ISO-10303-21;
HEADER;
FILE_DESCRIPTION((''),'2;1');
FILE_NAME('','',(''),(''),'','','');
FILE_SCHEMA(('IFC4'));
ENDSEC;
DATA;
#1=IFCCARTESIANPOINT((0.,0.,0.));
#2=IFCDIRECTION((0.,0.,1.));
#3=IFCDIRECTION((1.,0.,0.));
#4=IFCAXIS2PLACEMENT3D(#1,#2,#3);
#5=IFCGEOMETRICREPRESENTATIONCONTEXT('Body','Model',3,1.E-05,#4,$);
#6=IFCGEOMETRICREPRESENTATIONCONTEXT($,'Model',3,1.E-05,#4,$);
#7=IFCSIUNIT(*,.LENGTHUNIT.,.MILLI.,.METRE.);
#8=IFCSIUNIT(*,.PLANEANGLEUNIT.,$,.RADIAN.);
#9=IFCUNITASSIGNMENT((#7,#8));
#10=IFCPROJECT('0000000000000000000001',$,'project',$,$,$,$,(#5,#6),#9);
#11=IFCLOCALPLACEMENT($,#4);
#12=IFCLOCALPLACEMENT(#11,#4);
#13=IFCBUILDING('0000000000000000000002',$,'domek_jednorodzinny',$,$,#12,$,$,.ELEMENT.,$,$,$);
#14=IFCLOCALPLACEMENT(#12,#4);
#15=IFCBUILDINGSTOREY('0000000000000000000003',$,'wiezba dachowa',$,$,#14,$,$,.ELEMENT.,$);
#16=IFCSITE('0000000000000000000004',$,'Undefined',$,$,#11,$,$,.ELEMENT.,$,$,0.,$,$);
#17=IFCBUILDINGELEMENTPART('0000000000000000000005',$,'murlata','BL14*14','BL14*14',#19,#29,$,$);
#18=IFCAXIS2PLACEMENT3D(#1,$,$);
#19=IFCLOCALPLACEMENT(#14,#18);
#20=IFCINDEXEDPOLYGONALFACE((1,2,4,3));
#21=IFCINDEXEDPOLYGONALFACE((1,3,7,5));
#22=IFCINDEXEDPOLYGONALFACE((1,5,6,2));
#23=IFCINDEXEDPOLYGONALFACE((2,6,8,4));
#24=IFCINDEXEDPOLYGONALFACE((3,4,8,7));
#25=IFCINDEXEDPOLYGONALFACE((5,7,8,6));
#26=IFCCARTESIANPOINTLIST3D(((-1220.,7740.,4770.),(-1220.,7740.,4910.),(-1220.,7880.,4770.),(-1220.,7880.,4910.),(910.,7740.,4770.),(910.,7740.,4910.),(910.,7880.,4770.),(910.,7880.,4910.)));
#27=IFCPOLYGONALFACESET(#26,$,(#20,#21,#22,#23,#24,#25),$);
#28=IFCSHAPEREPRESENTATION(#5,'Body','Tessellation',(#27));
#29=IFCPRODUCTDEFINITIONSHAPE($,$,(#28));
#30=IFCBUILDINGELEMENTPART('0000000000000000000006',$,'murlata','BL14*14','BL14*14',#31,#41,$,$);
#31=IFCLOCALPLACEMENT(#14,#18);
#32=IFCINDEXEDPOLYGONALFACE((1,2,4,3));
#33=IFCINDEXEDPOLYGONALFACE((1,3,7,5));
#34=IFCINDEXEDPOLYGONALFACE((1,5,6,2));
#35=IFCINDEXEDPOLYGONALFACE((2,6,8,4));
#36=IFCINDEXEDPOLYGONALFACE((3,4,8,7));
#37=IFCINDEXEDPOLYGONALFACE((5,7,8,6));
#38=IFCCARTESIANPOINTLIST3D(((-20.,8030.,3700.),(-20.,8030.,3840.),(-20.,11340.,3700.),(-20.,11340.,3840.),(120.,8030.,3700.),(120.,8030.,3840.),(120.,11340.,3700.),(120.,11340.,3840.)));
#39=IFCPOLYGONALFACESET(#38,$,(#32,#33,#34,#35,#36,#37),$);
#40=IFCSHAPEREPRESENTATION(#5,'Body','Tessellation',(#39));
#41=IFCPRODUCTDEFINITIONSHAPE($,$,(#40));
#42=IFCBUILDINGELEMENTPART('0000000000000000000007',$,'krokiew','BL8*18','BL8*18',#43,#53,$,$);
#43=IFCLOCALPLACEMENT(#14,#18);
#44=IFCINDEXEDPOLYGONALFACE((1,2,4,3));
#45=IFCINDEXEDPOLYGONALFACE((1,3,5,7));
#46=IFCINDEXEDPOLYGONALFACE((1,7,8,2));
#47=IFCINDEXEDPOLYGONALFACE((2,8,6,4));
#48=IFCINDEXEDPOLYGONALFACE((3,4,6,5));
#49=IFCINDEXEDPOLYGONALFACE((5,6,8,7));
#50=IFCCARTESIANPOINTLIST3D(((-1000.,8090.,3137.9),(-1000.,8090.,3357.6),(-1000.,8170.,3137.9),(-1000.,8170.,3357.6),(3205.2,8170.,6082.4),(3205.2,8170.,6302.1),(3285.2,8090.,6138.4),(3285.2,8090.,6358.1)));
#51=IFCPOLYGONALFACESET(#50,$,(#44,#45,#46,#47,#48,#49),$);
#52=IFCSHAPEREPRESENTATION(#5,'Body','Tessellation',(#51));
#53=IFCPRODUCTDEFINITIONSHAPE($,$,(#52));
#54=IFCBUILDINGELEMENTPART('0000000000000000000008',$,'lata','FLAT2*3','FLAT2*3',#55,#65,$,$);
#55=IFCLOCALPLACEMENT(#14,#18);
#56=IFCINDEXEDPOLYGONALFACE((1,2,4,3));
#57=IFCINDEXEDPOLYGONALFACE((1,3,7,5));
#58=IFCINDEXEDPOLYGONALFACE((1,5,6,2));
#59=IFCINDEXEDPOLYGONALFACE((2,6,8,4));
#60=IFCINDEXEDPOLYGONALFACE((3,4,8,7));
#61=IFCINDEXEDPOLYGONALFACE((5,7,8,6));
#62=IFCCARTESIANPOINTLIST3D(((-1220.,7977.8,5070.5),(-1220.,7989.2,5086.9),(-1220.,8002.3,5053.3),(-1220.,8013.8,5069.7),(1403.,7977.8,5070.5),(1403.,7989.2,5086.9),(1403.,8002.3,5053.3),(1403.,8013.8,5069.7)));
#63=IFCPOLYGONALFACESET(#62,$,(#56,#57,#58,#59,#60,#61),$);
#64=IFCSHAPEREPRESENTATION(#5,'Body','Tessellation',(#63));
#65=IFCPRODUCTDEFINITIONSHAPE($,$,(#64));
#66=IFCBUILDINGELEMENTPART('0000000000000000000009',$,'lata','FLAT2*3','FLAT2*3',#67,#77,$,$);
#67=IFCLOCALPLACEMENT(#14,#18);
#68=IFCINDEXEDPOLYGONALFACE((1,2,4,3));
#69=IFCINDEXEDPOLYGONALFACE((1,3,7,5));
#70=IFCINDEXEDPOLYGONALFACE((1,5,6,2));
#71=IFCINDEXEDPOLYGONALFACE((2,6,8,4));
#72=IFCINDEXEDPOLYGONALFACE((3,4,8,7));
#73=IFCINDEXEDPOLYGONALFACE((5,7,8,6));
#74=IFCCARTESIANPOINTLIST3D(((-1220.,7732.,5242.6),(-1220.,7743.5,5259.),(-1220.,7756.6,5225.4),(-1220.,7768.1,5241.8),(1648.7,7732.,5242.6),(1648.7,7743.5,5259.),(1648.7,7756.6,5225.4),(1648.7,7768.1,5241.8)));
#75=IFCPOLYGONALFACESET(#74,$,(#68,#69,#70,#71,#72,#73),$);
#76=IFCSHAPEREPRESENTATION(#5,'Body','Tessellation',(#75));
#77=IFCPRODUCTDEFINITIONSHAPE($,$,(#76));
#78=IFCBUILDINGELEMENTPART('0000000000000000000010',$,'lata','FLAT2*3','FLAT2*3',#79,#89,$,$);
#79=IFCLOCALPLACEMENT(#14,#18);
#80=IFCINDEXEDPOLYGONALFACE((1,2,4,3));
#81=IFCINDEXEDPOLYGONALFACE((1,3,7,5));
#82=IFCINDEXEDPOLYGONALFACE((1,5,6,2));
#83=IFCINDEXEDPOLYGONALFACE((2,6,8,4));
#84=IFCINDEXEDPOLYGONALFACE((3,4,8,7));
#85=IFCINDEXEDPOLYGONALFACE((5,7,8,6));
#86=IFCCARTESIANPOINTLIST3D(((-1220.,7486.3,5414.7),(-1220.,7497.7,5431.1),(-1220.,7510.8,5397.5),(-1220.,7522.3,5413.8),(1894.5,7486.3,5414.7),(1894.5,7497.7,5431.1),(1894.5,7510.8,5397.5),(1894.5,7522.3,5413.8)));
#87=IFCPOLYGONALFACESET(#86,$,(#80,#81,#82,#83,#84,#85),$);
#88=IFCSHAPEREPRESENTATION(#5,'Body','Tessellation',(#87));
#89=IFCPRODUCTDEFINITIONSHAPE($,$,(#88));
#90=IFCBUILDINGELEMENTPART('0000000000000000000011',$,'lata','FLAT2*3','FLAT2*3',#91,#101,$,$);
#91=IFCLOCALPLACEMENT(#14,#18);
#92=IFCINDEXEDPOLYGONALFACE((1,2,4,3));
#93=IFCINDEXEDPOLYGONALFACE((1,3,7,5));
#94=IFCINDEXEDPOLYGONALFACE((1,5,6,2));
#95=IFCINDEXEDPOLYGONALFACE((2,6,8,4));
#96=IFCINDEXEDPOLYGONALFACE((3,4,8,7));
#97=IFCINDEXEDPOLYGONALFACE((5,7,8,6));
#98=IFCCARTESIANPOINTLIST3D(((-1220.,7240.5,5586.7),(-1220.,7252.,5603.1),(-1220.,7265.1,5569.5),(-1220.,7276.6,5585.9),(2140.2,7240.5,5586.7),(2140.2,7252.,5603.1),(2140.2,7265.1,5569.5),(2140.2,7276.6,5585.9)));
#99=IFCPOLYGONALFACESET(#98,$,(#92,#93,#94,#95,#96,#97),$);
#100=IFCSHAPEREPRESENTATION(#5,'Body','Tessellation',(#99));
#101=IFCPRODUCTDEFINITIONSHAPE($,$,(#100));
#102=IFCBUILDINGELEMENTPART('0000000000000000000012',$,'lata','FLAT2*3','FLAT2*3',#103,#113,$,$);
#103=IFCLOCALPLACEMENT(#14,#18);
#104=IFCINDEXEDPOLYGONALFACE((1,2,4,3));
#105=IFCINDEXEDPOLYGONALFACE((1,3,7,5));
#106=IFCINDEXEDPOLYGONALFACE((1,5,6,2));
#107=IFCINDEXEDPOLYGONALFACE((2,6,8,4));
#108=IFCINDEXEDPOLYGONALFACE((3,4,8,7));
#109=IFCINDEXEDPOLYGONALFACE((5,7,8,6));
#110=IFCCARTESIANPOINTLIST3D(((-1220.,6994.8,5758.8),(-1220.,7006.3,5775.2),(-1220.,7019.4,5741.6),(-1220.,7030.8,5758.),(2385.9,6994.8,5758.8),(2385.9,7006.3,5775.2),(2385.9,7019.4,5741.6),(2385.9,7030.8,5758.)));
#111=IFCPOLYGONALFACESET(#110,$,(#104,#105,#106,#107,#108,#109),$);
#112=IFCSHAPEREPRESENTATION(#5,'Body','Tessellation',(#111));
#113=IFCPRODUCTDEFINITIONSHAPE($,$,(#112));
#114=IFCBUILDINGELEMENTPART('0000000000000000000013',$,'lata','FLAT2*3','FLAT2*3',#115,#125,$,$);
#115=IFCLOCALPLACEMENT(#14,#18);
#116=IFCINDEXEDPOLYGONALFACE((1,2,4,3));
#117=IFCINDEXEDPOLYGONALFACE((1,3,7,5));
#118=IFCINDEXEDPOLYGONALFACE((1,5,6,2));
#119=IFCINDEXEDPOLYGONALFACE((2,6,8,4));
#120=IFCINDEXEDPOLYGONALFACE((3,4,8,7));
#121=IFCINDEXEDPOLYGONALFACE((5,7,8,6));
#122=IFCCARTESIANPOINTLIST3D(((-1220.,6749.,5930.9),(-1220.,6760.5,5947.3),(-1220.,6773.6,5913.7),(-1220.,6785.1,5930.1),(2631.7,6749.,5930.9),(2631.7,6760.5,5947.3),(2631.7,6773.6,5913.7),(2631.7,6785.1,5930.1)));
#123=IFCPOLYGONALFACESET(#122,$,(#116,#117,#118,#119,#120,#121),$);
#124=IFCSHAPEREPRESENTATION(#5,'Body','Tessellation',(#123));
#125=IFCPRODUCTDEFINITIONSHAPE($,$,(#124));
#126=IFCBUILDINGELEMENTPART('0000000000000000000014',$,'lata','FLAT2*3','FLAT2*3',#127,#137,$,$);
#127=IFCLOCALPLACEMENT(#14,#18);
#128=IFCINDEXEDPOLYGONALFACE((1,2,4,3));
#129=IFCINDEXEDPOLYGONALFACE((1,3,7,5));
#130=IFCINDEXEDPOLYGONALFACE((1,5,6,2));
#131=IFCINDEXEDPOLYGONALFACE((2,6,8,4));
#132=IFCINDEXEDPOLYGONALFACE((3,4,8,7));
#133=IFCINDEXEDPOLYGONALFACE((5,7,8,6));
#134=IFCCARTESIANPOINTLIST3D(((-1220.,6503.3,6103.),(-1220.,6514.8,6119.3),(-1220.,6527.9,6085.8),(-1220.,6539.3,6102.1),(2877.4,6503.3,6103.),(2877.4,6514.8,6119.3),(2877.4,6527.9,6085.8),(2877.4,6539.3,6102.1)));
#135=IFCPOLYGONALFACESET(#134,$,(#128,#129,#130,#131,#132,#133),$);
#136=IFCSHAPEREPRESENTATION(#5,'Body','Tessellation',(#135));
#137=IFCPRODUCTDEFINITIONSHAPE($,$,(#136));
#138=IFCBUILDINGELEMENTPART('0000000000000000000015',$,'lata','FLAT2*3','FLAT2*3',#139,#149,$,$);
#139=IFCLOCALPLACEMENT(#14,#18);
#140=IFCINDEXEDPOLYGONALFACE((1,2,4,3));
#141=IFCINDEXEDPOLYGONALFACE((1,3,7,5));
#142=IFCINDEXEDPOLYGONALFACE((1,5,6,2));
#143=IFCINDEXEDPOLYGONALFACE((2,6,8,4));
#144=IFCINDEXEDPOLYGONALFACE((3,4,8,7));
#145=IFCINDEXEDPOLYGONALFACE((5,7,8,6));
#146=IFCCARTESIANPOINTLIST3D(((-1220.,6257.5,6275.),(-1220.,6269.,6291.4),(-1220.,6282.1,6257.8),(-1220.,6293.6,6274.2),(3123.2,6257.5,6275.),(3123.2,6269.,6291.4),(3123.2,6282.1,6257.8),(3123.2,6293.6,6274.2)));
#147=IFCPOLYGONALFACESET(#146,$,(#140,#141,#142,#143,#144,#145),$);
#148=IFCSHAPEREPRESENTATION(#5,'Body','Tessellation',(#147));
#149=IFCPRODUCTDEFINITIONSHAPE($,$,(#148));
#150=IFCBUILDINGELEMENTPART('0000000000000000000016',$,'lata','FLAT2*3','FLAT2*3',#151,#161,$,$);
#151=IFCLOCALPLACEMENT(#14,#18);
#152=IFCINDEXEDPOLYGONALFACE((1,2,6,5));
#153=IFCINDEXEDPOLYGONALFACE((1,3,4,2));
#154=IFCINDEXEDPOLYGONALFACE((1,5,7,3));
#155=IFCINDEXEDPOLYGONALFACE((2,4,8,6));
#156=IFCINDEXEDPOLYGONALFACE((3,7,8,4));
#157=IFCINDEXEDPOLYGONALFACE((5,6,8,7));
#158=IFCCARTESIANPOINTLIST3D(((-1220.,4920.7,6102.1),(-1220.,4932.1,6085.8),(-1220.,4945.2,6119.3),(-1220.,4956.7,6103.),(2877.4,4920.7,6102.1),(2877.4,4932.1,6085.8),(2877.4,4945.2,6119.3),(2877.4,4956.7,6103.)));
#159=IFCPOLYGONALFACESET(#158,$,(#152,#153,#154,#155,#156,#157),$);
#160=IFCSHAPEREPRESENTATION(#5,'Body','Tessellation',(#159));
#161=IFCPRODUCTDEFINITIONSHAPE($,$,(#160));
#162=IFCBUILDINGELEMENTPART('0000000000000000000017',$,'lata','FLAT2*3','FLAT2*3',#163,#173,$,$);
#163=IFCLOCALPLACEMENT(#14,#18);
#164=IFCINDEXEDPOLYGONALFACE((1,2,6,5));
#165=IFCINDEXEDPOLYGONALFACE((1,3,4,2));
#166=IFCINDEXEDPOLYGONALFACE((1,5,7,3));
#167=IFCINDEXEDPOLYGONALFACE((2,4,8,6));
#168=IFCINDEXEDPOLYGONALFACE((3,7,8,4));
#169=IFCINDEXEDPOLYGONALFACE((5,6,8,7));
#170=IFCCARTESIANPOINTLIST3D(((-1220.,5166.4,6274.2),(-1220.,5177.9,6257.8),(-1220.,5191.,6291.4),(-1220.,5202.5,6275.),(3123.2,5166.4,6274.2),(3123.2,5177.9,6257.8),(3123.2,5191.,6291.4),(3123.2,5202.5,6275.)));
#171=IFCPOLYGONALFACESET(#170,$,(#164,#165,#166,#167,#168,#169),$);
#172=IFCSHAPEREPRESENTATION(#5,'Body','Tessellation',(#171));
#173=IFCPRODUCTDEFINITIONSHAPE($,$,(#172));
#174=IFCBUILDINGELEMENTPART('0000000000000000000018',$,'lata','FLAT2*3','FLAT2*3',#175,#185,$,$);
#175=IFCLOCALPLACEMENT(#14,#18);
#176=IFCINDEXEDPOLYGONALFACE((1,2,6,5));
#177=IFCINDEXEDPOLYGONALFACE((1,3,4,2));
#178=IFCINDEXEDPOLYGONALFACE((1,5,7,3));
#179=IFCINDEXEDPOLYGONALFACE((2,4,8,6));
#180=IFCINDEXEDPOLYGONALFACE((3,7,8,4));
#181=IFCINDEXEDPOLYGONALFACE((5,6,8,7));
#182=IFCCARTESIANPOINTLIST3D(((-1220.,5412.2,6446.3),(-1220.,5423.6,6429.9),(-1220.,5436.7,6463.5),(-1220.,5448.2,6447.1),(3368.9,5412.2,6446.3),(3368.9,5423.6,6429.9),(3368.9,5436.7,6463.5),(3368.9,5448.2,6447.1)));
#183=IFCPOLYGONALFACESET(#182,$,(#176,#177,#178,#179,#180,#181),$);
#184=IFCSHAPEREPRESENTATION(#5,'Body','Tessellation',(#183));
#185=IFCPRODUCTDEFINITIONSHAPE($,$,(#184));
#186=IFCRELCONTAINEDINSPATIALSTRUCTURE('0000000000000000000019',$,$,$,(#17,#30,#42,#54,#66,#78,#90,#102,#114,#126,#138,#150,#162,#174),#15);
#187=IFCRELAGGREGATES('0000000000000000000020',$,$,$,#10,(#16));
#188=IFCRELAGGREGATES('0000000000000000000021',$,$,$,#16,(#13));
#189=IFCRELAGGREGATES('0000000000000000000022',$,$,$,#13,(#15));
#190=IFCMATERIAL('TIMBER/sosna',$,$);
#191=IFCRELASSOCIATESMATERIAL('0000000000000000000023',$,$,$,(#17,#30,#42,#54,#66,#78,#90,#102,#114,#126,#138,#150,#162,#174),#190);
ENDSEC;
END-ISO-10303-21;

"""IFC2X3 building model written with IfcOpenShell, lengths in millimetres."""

from ifc_helpers import new_model, si_unit, frame, origin_with_axes, origin_2d_with_axis, place, context, project, spatial, rectangle, extrude, clip, halfspace, material, element, save


model = new_model("IFC2X3")

# Units and contexts
model_context_1 = context("Model", 3, precision=1e-05, world=origin_with_axes(), identifier="Body")
model_context_2 = context("Model", 3, precision=1e-05, world=origin_with_axes())
ifc_project = project(units=[si_unit("LENGTHUNIT", "METRE", prefix="MILLI"), si_unit("PLANEANGLEUNIT", "RADIAN")], contexts=[model_context_1, model_context_2])

# Site, building, storey
site_placement = place(None, origin_with_axes())
site = spatial("IfcSite", under=ifc_project, at=site_placement, Name="Undefined", CompositionType="ELEMENT", RefElevation=0.0)
building_placement = place(site_placement, origin_with_axes())
building = spatial("IfcBuilding", under=site, at=building_placement, Name="domek_jednorodzinny", CompositionType="ELEMENT")
storey_placement = place(building_placement, origin_with_axes())
storey = spatial("IfcBuildingStorey", under=building, at=storey_placement, Name="wiezba dachowa", CompositionType="ELEMENT")

# Building element parts
ifc_material = material(Name="TIMBER/sosna")
building_element_part_1_placement = place(storey_placement, frame((910.0, 7810.0, 4840.0), z_axis=(0.0, 0.0, 1.0), x_axis=(-1.0, 0.0, 0.0)))
element("IfcBuildingElementPart", 1, at=building_element_part_1_placement, inside=storey, material=ifc_material, Name="murlata", Description="BL14*14", ObjectType="BL14*14", context=model_context_1, shape_type="SweptSolid", body=[
    extrude(rectangle(XDim=140.0, YDim=140.0, at=origin_2d_with_axis()), frame((2130.0, 0.0, 0.0), z_axis=(-1.0, 0.0, 0.0), x_axis=(0.0, -1.0, 0.0)), (0.0, 0.0, 1.0), 2130.0),
])
building_element_part_2_placement = place(storey_placement, frame((50.0, 8030.0, 3770.0), z_axis=(0.0, 0.0, 1.0), x_axis=(0.0, 1.0, 0.0)))
element("IfcBuildingElementPart", 2, at=building_element_part_2_placement, inside=storey, material=ifc_material, Name="murlata", Description="BL14*14", ObjectType="BL14*14", context=model_context_1, shape_type="SweptSolid", body=[
    extrude(rectangle(XDim=140.0, YDim=140.0, at=origin_2d_with_axis()), frame((3310.0, 0.0, 0.0), z_axis=(-1.0, 0.0, 0.0), x_axis=(0.0, -1.0, 0.0)), (0.0, 0.0, 1.0), 3310.0),
])
building_element_part_3_placement = place(storey_placement, frame((-1051.6, 8130.0, 3211.6), z_axis=(-0.573576, 0.0, 0.819152), x_axis=(0.819152, 0.0, 0.573576)))
element("IfcBuildingElementPart", 3, at=building_element_part_3_placement, inside=storey, material=ifc_material, Name="krokiew", Description="BL8*18", ObjectType="BL8*18", context=model_context_1, shape_type="Clipping", body=[
    clip(clip(extrude(rectangle(XDim=80.0, YDim=180.0, at=origin_2d_with_axis()), frame((5841.8, 0.0, 0.0), z_axis=(-1.0, 0.0, 0.0), x_axis=(0.0, -1.0, 0.0)), (0.0, 0.0, 1.0), 5841.8), halfspace(frame((0.0, 40.0, -90.0), z_axis=(-0.819152, 0.0, 0.573576), x_axis=(0.573578, 0.0, 0.819151)), False)), halfspace(frame((5231.3, -40.0, -90.0), z_axis=(0.579226, 0.707109, -0.405579), x_axis=(0.573578, 0.0, 0.819151)), False)),
])
building_element_part_4_placement = place(storey_placement, frame((1403.0, 7995.8, 5070.1), z_axis=(0.0, -0.819154, 0.573574), x_axis=(-1.0, 0.0, 0.0)))
element("IfcBuildingElementPart", 4, at=building_element_part_4_placement, inside=storey, material=ifc_material, Name="lata", Description="FLAT2*3", ObjectType="FLAT2*3", context=model_context_1, shape_type="SweptSolid", body=[
    extrude(rectangle(XDim=20.0, YDim=30.0, at=origin_2d_with_axis()), frame((2622.9, 0.0, 0.0), z_axis=(-1.0, 0.0, 0.0), x_axis=(0.0, -1.0, 0.0)), (0.0, 0.0, 1.0), 2622.9),
])
building_element_part_5_placement = place(storey_placement, frame((1648.7, 7750.0, 5242.2), z_axis=(0.0, -0.819154, 0.573574), x_axis=(-1.0, 0.0, 0.0)))
element("IfcBuildingElementPart", 5, at=building_element_part_5_placement, inside=storey, material=ifc_material, Name="lata", Description="FLAT2*3", ObjectType="FLAT2*3", context=model_context_1, shape_type="SweptSolid", body=[
    extrude(rectangle(XDim=20.0, YDim=30.0, at=origin_2d_with_axis()), frame((2868.7, 0.0, 0.0), z_axis=(-1.0, 0.0, 0.0), x_axis=(0.0, -1.0, 0.0)), (0.0, 0.0, 1.0), 2868.7),
])
building_element_part_6_placement = place(storey_placement, frame((1894.5, 7504.3, 5414.3), z_axis=(0.0, -0.819154, 0.573574), x_axis=(-1.0, 0.0, 0.0)))
element("IfcBuildingElementPart", 6, at=building_element_part_6_placement, inside=storey, material=ifc_material, Name="lata", Description="FLAT2*3", ObjectType="FLAT2*3", context=model_context_1, shape_type="SweptSolid", body=[
    extrude(rectangle(XDim=20.0, YDim=30.0, at=origin_2d_with_axis()), frame((3114.4, 0.0, 0.0), z_axis=(-1.0, 0.0, 0.0), x_axis=(0.0, -1.0, 0.0)), (0.0, 0.0, 1.0), 3114.4),
])
building_element_part_7_placement = place(storey_placement, frame((2140.2, 7258.6, 5586.3), z_axis=(0.0, -0.819154, 0.573574), x_axis=(-1.0, 0.0, 0.0)))
element("IfcBuildingElementPart", 7, at=building_element_part_7_placement, inside=storey, material=ifc_material, Name="lata", Description="FLAT2*3", ObjectType="FLAT2*3", context=model_context_1, shape_type="SweptSolid", body=[
    extrude(rectangle(XDim=20.0, YDim=30.0, at=origin_2d_with_axis()), frame((3360.2, 0.0, 0.0), z_axis=(-1.0, 0.0, 0.0), x_axis=(0.0, -1.0, 0.0)), (0.0, 0.0, 1.0), 3360.2),
])
building_element_part_8_placement = place(storey_placement, frame((2385.9, 7012.8, 5758.4), z_axis=(0.0, -0.819154, 0.573574), x_axis=(-1.0, 0.0, 0.0)))
element("IfcBuildingElementPart", 8, at=building_element_part_8_placement, inside=storey, material=ifc_material, Name="lata", Description="FLAT2*3", ObjectType="FLAT2*3", context=model_context_1, shape_type="SweptSolid", body=[
    extrude(rectangle(XDim=20.0, YDim=30.0, at=origin_2d_with_axis()), frame((3605.9, 0.0, 0.0), z_axis=(-1.0, 0.0, 0.0), x_axis=(0.0, -1.0, 0.0)), (0.0, 0.0, 1.0), 3605.9),
])
building_element_part_9_placement = place(storey_placement, frame((2631.7, 6767.1, 5930.5), z_axis=(0.0, -0.819154, 0.573574), x_axis=(-1.0, 0.0, 0.0)))
element("IfcBuildingElementPart", 9, at=building_element_part_9_placement, inside=storey, material=ifc_material, Name="lata", Description="FLAT2*3", ObjectType="FLAT2*3", context=model_context_1, shape_type="SweptSolid", body=[
    extrude(rectangle(XDim=20.0, YDim=30.0, at=origin_2d_with_axis()), frame((3851.7, 0.0, 0.0), z_axis=(-1.0, 0.0, 0.0), x_axis=(0.0, -1.0, 0.0)), (0.0, 0.0, 1.0), 3851.7),
])
building_element_part_10_placement = place(storey_placement, frame((2877.4, 6521.3, 6102.5), z_axis=(0.0, -0.819154, 0.573574), x_axis=(-1.0, 0.0, 0.0)))
element("IfcBuildingElementPart", 10, at=building_element_part_10_placement, inside=storey, material=ifc_material, Name="lata", Description="FLAT2*3", ObjectType="FLAT2*3", context=model_context_1, shape_type="SweptSolid", body=[
    extrude(rectangle(XDim=20.0, YDim=30.0, at=origin_2d_with_axis()), frame((4097.4, 0.0, 0.0), z_axis=(-1.0, 0.0, 0.0), x_axis=(0.0, -1.0, 0.0)), (0.0, 0.0, 1.0), 4097.4),
])
building_element_part_11_placement = place(storey_placement, frame((3123.2, 6275.6, 6274.6), z_axis=(0.0, -0.819154, 0.573574), x_axis=(-1.0, 0.0, 0.0)))
element("IfcBuildingElementPart", 11, at=building_element_part_11_placement, inside=storey, material=ifc_material, Name="lata", Description="FLAT2*3", ObjectType="FLAT2*3", context=model_context_1, shape_type="SweptSolid", body=[
    extrude(rectangle(XDim=20.0, YDim=30.0, at=origin_2d_with_axis()), frame((4343.2, 0.0, 0.0), z_axis=(-1.0, 0.0, 0.0), x_axis=(0.0, -1.0, 0.0)), (0.0, 0.0, 1.0), 4343.2),
])
building_element_part_12_placement = place(storey_placement, frame((2877.4, 4938.7, 6102.5), z_axis=(0.0, 0.819154, 0.573574), x_axis=(-1.0, 0.0, 0.0)))
element("IfcBuildingElementPart", 12, at=building_element_part_12_placement, inside=storey, material=ifc_material, Name="lata", Description="FLAT2*3", ObjectType="FLAT2*3", context=model_context_1, shape_type="SweptSolid", body=[
    extrude(rectangle(XDim=20.0, YDim=30.0, at=origin_2d_with_axis()), frame((4097.4, 0.0, 0.0), z_axis=(-1.0, 0.0, 0.0), x_axis=(0.0, -1.0, 0.0)), (0.0, 0.0, 1.0), 4097.4),
])
building_element_part_13_placement = place(storey_placement, frame((3123.2, 5184.4, 6274.6), z_axis=(0.0, 0.819154, 0.573574), x_axis=(-1.0, 0.0, 0.0)))
element("IfcBuildingElementPart", 13, at=building_element_part_13_placement, inside=storey, material=ifc_material, Name="lata", Description="FLAT2*3", ObjectType="FLAT2*3", context=model_context_1, shape_type="SweptSolid", body=[
    extrude(rectangle(XDim=20.0, YDim=30.0, at=origin_2d_with_axis()), frame((4343.2, 0.0, 0.0), z_axis=(-1.0, 0.0, 0.0), x_axis=(0.0, -1.0, 0.0)), (0.0, 0.0, 1.0), 4343.2),
])
building_element_part_14_placement = place(storey_placement, frame((3368.9, 5430.2, 6446.7), z_axis=(0.0, 0.819154, 0.573574), x_axis=(-1.0, 0.0, 0.0)))
element("IfcBuildingElementPart", 14, at=building_element_part_14_placement, inside=storey, material=ifc_material, Name="lata", Description="FLAT2*3", ObjectType="FLAT2*3", context=model_context_1, shape_type="SweptSolid", body=[
    extrude(rectangle(XDim=20.0, YDim=30.0, at=origin_2d_with_axis()), frame((4588.9, 0.0, 0.0), z_axis=(-1.0, 0.0, 0.0), x_axis=(0.0, -1.0, 0.0)), (0.0, 0.0, 1.0), 4588.9),
])

save(model, "model.ifc")
